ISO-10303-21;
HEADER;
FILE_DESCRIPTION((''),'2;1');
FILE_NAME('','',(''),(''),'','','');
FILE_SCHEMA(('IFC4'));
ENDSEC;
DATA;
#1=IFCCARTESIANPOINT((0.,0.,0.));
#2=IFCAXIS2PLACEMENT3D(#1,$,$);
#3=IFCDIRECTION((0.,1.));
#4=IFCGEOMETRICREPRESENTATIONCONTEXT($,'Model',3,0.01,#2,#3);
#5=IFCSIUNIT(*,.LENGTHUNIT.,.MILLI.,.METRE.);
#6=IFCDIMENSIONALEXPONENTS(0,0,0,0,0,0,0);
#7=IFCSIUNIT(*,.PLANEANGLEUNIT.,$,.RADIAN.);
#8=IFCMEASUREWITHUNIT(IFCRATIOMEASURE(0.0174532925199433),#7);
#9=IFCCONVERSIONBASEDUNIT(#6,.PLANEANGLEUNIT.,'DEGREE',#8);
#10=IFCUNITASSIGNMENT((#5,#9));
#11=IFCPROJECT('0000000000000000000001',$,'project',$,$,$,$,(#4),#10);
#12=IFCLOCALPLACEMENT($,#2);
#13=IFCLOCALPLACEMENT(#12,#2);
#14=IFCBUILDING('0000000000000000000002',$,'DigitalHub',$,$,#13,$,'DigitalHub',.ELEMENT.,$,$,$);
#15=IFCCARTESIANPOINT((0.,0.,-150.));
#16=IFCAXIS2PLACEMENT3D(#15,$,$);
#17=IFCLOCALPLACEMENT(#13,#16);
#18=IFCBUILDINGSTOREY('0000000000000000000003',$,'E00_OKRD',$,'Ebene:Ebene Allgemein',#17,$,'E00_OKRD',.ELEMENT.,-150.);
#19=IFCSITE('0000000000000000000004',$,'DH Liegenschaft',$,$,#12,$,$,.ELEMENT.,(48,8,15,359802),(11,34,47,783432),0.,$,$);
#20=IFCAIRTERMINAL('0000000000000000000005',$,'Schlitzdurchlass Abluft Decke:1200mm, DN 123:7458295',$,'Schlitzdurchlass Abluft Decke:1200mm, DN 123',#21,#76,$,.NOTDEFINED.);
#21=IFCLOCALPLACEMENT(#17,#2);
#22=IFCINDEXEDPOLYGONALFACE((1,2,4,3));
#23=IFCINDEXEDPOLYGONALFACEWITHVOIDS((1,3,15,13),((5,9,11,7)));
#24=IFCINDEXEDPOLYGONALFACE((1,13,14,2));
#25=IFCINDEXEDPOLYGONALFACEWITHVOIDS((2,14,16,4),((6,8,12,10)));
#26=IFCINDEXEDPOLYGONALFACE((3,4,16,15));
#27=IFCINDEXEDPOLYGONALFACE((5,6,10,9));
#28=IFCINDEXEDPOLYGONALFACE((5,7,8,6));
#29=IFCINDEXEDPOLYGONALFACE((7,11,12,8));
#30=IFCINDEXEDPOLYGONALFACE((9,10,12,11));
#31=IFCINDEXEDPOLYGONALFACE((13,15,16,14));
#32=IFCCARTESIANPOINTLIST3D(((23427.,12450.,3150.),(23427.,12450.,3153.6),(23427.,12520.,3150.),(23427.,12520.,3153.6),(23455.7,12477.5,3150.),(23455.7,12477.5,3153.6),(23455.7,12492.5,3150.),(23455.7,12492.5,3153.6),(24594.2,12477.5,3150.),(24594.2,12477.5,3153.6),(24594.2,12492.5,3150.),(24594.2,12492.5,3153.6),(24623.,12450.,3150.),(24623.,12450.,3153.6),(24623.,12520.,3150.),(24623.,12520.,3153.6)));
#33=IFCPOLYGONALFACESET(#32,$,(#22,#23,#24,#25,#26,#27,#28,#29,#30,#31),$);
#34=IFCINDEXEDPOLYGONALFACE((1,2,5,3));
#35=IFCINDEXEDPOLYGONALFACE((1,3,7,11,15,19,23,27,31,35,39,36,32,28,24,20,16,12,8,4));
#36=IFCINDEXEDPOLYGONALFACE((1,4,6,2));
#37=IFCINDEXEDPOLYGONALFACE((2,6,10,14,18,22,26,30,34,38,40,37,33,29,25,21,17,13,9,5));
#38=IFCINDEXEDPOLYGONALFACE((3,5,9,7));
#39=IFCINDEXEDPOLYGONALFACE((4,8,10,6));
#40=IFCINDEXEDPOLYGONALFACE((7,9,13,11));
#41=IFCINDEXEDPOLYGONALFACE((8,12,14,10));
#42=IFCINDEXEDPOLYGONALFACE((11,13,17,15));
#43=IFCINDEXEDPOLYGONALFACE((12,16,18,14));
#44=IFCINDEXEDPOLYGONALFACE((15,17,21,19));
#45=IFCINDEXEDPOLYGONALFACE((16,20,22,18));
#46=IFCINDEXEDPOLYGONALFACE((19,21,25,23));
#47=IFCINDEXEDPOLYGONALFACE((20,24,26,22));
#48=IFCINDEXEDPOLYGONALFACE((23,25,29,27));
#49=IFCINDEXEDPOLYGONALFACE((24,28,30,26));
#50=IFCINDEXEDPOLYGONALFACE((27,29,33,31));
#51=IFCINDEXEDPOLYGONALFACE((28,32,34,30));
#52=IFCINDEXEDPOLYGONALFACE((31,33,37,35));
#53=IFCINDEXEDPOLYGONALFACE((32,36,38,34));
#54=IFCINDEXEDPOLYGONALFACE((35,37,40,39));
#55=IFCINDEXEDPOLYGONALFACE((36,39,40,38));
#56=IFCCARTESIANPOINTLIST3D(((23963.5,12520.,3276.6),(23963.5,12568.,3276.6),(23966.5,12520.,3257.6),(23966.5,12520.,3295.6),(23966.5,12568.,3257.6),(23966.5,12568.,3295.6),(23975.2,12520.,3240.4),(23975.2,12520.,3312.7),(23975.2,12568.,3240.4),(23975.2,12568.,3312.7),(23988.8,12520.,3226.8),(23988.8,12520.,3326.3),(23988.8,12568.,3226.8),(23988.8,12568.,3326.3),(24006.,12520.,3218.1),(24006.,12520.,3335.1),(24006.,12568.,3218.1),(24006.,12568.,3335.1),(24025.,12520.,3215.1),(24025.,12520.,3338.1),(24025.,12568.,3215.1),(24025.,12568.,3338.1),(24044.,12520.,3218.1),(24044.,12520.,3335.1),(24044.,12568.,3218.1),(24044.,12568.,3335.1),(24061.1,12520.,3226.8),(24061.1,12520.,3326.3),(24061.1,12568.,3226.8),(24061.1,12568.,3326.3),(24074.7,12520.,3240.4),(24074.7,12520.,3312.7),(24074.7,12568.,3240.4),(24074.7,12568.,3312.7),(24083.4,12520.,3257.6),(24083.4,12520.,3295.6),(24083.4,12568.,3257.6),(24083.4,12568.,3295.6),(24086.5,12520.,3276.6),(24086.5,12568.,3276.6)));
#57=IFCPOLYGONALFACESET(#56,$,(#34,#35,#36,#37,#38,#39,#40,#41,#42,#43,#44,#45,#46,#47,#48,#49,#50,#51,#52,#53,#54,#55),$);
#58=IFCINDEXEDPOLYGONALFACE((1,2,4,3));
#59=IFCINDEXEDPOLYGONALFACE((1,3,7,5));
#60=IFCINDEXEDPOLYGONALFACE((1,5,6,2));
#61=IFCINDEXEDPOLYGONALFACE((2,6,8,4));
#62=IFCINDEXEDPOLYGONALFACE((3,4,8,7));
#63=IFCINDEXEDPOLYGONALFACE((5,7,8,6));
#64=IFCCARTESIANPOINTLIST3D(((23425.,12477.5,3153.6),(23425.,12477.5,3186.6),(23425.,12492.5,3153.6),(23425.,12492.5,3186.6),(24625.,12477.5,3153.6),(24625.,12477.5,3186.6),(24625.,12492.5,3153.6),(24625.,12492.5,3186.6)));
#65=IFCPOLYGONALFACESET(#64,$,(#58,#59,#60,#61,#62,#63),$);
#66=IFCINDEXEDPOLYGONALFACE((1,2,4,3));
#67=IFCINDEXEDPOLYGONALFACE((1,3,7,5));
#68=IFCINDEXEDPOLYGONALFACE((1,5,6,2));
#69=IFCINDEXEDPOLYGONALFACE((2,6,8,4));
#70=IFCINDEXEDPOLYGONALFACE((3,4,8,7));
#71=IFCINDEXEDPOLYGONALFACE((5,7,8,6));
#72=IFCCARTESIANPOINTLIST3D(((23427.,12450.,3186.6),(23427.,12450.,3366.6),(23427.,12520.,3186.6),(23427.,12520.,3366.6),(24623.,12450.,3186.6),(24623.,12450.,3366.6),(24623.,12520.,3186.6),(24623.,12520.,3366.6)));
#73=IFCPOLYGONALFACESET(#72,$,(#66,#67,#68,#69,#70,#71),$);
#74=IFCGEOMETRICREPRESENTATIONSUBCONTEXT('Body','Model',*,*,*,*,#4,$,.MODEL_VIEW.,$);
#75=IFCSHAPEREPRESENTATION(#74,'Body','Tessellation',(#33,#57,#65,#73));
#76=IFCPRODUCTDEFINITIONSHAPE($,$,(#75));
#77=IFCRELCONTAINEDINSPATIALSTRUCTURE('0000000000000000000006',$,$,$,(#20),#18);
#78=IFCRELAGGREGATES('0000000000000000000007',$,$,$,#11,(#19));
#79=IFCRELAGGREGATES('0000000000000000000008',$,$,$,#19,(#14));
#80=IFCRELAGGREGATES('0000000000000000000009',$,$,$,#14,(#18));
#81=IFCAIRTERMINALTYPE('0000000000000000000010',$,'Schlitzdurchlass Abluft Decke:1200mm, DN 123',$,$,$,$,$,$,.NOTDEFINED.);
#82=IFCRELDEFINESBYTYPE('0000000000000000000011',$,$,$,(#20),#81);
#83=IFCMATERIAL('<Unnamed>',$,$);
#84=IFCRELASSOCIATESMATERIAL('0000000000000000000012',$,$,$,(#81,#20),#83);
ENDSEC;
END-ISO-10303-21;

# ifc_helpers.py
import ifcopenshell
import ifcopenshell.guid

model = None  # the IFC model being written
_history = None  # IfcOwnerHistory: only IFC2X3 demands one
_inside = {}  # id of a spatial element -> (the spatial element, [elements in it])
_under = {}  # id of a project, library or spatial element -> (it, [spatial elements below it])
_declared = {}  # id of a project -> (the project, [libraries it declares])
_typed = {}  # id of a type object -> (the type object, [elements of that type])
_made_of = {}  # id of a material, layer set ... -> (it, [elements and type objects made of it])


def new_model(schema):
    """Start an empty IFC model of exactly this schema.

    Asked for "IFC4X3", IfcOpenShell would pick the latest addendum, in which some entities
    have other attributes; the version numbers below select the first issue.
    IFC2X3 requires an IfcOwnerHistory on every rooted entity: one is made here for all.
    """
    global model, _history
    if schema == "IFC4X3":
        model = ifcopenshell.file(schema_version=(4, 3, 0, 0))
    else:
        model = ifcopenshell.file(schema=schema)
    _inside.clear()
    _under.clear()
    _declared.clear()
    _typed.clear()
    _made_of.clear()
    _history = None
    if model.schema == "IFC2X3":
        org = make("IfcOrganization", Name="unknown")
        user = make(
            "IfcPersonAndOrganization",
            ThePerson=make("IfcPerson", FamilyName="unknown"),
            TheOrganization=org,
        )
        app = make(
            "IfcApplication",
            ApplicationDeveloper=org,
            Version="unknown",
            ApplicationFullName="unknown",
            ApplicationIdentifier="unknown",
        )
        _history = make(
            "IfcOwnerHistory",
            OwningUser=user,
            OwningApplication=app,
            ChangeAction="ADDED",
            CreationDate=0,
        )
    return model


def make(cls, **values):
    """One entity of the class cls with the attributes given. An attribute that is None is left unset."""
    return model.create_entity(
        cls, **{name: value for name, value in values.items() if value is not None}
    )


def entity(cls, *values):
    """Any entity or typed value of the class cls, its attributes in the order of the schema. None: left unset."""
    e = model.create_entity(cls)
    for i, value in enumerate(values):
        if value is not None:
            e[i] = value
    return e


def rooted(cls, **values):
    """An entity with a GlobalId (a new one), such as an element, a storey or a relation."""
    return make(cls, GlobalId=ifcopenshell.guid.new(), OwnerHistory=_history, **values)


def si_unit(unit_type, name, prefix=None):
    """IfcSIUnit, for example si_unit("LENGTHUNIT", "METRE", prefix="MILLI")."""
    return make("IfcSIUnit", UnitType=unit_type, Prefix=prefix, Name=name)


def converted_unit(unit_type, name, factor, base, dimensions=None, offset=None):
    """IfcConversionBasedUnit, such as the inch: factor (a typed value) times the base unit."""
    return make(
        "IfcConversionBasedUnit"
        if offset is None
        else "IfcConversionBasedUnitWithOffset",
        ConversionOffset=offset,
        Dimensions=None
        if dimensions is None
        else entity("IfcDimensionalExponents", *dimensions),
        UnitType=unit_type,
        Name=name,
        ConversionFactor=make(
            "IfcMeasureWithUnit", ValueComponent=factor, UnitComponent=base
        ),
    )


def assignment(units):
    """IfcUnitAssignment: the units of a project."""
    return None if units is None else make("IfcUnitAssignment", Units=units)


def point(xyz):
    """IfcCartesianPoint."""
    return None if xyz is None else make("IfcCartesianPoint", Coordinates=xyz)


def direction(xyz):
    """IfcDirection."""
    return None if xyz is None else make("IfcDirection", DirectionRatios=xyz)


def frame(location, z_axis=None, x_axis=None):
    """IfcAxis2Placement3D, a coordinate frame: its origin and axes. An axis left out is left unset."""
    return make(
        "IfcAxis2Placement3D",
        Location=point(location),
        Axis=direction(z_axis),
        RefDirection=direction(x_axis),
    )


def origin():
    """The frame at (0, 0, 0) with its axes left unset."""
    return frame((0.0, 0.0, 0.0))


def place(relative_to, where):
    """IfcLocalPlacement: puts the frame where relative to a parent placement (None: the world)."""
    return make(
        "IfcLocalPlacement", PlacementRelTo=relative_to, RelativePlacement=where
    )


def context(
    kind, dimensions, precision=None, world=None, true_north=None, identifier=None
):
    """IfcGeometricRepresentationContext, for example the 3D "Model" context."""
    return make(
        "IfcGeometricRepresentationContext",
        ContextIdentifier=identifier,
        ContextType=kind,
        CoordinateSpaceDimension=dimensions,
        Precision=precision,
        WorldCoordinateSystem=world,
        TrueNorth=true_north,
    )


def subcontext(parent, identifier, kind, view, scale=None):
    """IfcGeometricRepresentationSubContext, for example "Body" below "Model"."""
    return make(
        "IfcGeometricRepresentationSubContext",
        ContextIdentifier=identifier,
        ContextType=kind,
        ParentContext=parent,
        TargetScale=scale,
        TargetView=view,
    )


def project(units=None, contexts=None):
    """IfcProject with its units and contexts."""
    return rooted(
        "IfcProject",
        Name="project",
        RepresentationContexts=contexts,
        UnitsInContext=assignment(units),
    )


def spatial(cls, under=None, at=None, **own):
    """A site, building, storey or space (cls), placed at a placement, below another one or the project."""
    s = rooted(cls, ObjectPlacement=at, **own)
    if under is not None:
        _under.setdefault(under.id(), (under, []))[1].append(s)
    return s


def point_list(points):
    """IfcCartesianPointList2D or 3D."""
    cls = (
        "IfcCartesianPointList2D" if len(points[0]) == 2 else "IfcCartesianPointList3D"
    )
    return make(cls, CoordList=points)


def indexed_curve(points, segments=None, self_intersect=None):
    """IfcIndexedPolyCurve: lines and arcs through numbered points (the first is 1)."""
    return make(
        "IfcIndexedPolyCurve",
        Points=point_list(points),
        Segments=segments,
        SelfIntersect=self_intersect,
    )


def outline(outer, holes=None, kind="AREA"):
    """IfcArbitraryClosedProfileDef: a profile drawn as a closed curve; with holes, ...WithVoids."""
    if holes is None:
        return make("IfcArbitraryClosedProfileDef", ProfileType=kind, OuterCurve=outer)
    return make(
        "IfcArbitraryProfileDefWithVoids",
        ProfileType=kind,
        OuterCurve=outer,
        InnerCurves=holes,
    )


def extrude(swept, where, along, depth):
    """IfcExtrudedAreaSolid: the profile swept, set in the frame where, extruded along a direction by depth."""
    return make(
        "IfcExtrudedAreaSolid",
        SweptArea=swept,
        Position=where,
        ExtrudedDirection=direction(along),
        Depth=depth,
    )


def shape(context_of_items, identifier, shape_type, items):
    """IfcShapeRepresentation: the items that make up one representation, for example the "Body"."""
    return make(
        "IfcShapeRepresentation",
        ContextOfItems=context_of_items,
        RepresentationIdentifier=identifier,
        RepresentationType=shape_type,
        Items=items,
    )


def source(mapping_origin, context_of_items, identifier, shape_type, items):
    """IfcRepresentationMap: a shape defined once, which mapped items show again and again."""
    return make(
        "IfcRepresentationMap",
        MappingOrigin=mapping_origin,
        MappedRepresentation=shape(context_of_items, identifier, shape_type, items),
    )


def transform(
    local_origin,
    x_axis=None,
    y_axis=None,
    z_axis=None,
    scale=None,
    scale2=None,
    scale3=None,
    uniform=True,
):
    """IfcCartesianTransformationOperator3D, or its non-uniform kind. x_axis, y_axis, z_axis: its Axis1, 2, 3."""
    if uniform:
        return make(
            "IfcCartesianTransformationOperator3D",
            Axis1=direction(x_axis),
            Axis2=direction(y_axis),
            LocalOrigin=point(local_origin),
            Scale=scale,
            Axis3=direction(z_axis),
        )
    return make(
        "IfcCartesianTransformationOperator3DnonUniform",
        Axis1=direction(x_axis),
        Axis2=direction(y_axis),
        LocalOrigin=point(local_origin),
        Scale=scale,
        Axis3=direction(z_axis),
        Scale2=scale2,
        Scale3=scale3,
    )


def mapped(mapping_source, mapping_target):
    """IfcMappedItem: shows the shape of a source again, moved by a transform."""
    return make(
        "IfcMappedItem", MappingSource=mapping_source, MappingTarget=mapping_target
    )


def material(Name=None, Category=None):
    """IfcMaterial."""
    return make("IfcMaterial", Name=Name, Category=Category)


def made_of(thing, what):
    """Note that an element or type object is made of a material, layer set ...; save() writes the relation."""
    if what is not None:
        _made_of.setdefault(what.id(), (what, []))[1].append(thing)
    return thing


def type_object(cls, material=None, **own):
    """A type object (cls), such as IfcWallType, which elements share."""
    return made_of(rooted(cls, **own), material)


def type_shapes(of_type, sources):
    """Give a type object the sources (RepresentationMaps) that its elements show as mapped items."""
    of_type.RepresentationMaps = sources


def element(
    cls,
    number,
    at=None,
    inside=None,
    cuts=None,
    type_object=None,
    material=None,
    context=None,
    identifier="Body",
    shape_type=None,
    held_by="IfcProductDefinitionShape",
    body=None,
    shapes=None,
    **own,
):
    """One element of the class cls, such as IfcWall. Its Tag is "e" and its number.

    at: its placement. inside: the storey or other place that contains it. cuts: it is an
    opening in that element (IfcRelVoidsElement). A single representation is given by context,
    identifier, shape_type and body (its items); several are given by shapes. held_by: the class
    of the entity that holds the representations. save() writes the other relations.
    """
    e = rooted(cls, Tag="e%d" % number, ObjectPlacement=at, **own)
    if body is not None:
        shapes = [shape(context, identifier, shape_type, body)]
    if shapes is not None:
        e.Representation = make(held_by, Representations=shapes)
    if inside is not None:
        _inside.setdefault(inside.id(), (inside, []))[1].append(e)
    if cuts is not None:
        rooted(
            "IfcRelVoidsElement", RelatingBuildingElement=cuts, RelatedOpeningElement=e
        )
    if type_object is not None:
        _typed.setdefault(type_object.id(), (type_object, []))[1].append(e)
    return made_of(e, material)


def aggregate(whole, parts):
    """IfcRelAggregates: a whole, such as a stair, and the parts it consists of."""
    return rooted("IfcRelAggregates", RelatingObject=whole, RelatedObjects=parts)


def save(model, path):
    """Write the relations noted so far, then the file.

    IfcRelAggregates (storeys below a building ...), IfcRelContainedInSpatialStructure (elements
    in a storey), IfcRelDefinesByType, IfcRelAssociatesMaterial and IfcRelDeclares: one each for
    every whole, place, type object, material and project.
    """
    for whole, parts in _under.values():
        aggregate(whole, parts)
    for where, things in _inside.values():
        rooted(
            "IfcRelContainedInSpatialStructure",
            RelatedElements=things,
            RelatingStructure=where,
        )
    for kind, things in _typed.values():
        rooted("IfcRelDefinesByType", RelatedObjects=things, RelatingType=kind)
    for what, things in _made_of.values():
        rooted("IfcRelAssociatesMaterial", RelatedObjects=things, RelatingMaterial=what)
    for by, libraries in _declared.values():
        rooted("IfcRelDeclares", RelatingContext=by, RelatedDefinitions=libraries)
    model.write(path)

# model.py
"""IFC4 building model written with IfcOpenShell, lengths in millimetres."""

from ifc_helpers import new_model, entity, si_unit, converted_unit, direction, frame, origin, place, context, subcontext, project, spatial, indexed_curve, outline, extrude, source, transform, mapped, material, type_object, type_shapes, element, save


model = new_model("IFC4")

# Units and contexts
model_context = context("Model", 3, precision=0.01, world=origin(), true_north=direction((0.0, 1.0)))
body_context = subcontext(model_context, "Body", "Model", "MODEL_VIEW")
ifc_project = project(units=[si_unit("LENGTHUNIT", "METRE", prefix="MILLI"), converted_unit("PLANEANGLEUNIT", "DEGREE", entity("IfcRatioMeasure", 0.0174532925199433), si_unit("PLANEANGLEUNIT", "RADIAN"), dimensions=[0, 0, 0, 0, 0, 0, 0])], contexts=[model_context])

# Site, building, storey
site_placement = place(None, origin())
site = spatial("IfcSite", under=ifc_project, at=site_placement, Name="DH Liegenschaft", CompositionType="ELEMENT", RefLatitude=(48, 8, 15, 359802), RefLongitude=(11, 34, 47, 783432), RefElevation=0.0)
building_placement = place(site_placement, origin())
building = spatial("IfcBuilding", under=site, at=building_placement, Name="DigitalHub", LongName="DigitalHub", CompositionType="ELEMENT")
storey_placement = place(building_placement, frame((0.0, 0.0, -150.0)))
storey = spatial("IfcBuildingStorey", under=building, at=storey_placement, Name="E00_OKRD", ObjectType="Ebene:Ebene Allgemein", LongName="E00_OKRD", CompositionType="ELEMENT", Elevation=-150.0)

# Shared definitions
ifc_material_1 = material(Name="<Unnamed>")

# Air terminal
air_terminal_type_1 = type_object("IfcAirTerminalType", Name="Schlitzdurchlass Abluft Decke:1200mm, DN 123", PredefinedType="NOTDEFINED", material=ifc_material_1)
shared_shape_1 = source(origin(), body_context, "Body", "SweptSolid", [
    extrude(outline(indexed_curve([(-598.0, -35.0), (598.0, -35.0), (598.0, 35.0), (-598.0, 35.0), (-598.0, -35.0)], self_intersect=False), holes=[indexed_curve([(-569.2, -7.5), (-569.2, 7.5), (569.2, 7.5), (569.2, -7.5), (-569.2, -7.5)], self_intersect=False)]), frame((0.0, 0.0, 0.0), z_axis=(0.0, 0.0, 1.0), x_axis=(-1.0, 0.0, 0.0)), (0.0, 0.0, 1.0), 3.6),
    extrude(outline(indexed_curve([(61.5, 0.0), (58.5, 19.0), (49.8, 36.1), (36.1, 49.8), (19.0, 58.5), (0.0, 61.5), (-19.0, 58.5), (-36.1, 49.8), (-49.8, 36.1), (-58.5, 19.0), (-61.5, 0.0), (-58.5, -19.0), (-49.8, -36.1), (-36.1, -49.8), (-19.0, -58.5), (0.0, -61.5), (19.0, -58.5), (36.1, -49.8), (49.8, -36.1), (58.5, -19.0), (61.5, 0.0)], self_intersect=False)), frame((0.0, 35.0, 126.6), z_axis=(0.0, 1.0, 0.0), x_axis=(-1.0, 0.0, 0.0)), (0.0, 0.0, 1.0), 48.0),
    extrude(outline(indexed_curve([(-600.0, -7.5), (600.0, -7.5), (600.0, 7.5), (-600.0, 7.5), (-600.0, -7.5)], self_intersect=False)), frame((0.0, 0.0, 3.6), z_axis=(0.0, 0.0, 1.0), x_axis=(-1.0, 0.0, 0.0)), (0.0, 0.0, 1.0), 33.0),
    extrude(outline(indexed_curve([(-598.0, -35.0), (598.0, -35.0), (598.0, 35.0), (-598.0, 35.0), (-598.0, -35.0)], self_intersect=False)), frame((0.0, 0.0, 36.6), z_axis=(0.0, 0.0, 1.0), x_axis=(-1.0, 0.0, 0.0)), (0.0, 0.0, 1.0), 180.0),
])
type_shapes(air_terminal_type_1, [shared_shape_1])
for number, where, name in (
    (1, (24025.0, 12485.0, 3150.0), "Schlitzdurchlass Abluft Decke:1200mm, DN 123:7458295"),
):
    element("IfcAirTerminal", number, at=place(storey_placement, frame(where)), inside=storey, type_object=air_terminal_type_1, material=ifc_material_1, Name=name, ObjectType="Schlitzdurchlass Abluft Decke:1200mm, DN 123", PredefinedType="NOTDEFINED", context=body_context, shape_type="MappedRepresentation", body=[
        mapped(shared_shape_1, transform((0.0, 0.0, 0.0), scale=1.0)),
    ])

save(model, "model.ifc")
